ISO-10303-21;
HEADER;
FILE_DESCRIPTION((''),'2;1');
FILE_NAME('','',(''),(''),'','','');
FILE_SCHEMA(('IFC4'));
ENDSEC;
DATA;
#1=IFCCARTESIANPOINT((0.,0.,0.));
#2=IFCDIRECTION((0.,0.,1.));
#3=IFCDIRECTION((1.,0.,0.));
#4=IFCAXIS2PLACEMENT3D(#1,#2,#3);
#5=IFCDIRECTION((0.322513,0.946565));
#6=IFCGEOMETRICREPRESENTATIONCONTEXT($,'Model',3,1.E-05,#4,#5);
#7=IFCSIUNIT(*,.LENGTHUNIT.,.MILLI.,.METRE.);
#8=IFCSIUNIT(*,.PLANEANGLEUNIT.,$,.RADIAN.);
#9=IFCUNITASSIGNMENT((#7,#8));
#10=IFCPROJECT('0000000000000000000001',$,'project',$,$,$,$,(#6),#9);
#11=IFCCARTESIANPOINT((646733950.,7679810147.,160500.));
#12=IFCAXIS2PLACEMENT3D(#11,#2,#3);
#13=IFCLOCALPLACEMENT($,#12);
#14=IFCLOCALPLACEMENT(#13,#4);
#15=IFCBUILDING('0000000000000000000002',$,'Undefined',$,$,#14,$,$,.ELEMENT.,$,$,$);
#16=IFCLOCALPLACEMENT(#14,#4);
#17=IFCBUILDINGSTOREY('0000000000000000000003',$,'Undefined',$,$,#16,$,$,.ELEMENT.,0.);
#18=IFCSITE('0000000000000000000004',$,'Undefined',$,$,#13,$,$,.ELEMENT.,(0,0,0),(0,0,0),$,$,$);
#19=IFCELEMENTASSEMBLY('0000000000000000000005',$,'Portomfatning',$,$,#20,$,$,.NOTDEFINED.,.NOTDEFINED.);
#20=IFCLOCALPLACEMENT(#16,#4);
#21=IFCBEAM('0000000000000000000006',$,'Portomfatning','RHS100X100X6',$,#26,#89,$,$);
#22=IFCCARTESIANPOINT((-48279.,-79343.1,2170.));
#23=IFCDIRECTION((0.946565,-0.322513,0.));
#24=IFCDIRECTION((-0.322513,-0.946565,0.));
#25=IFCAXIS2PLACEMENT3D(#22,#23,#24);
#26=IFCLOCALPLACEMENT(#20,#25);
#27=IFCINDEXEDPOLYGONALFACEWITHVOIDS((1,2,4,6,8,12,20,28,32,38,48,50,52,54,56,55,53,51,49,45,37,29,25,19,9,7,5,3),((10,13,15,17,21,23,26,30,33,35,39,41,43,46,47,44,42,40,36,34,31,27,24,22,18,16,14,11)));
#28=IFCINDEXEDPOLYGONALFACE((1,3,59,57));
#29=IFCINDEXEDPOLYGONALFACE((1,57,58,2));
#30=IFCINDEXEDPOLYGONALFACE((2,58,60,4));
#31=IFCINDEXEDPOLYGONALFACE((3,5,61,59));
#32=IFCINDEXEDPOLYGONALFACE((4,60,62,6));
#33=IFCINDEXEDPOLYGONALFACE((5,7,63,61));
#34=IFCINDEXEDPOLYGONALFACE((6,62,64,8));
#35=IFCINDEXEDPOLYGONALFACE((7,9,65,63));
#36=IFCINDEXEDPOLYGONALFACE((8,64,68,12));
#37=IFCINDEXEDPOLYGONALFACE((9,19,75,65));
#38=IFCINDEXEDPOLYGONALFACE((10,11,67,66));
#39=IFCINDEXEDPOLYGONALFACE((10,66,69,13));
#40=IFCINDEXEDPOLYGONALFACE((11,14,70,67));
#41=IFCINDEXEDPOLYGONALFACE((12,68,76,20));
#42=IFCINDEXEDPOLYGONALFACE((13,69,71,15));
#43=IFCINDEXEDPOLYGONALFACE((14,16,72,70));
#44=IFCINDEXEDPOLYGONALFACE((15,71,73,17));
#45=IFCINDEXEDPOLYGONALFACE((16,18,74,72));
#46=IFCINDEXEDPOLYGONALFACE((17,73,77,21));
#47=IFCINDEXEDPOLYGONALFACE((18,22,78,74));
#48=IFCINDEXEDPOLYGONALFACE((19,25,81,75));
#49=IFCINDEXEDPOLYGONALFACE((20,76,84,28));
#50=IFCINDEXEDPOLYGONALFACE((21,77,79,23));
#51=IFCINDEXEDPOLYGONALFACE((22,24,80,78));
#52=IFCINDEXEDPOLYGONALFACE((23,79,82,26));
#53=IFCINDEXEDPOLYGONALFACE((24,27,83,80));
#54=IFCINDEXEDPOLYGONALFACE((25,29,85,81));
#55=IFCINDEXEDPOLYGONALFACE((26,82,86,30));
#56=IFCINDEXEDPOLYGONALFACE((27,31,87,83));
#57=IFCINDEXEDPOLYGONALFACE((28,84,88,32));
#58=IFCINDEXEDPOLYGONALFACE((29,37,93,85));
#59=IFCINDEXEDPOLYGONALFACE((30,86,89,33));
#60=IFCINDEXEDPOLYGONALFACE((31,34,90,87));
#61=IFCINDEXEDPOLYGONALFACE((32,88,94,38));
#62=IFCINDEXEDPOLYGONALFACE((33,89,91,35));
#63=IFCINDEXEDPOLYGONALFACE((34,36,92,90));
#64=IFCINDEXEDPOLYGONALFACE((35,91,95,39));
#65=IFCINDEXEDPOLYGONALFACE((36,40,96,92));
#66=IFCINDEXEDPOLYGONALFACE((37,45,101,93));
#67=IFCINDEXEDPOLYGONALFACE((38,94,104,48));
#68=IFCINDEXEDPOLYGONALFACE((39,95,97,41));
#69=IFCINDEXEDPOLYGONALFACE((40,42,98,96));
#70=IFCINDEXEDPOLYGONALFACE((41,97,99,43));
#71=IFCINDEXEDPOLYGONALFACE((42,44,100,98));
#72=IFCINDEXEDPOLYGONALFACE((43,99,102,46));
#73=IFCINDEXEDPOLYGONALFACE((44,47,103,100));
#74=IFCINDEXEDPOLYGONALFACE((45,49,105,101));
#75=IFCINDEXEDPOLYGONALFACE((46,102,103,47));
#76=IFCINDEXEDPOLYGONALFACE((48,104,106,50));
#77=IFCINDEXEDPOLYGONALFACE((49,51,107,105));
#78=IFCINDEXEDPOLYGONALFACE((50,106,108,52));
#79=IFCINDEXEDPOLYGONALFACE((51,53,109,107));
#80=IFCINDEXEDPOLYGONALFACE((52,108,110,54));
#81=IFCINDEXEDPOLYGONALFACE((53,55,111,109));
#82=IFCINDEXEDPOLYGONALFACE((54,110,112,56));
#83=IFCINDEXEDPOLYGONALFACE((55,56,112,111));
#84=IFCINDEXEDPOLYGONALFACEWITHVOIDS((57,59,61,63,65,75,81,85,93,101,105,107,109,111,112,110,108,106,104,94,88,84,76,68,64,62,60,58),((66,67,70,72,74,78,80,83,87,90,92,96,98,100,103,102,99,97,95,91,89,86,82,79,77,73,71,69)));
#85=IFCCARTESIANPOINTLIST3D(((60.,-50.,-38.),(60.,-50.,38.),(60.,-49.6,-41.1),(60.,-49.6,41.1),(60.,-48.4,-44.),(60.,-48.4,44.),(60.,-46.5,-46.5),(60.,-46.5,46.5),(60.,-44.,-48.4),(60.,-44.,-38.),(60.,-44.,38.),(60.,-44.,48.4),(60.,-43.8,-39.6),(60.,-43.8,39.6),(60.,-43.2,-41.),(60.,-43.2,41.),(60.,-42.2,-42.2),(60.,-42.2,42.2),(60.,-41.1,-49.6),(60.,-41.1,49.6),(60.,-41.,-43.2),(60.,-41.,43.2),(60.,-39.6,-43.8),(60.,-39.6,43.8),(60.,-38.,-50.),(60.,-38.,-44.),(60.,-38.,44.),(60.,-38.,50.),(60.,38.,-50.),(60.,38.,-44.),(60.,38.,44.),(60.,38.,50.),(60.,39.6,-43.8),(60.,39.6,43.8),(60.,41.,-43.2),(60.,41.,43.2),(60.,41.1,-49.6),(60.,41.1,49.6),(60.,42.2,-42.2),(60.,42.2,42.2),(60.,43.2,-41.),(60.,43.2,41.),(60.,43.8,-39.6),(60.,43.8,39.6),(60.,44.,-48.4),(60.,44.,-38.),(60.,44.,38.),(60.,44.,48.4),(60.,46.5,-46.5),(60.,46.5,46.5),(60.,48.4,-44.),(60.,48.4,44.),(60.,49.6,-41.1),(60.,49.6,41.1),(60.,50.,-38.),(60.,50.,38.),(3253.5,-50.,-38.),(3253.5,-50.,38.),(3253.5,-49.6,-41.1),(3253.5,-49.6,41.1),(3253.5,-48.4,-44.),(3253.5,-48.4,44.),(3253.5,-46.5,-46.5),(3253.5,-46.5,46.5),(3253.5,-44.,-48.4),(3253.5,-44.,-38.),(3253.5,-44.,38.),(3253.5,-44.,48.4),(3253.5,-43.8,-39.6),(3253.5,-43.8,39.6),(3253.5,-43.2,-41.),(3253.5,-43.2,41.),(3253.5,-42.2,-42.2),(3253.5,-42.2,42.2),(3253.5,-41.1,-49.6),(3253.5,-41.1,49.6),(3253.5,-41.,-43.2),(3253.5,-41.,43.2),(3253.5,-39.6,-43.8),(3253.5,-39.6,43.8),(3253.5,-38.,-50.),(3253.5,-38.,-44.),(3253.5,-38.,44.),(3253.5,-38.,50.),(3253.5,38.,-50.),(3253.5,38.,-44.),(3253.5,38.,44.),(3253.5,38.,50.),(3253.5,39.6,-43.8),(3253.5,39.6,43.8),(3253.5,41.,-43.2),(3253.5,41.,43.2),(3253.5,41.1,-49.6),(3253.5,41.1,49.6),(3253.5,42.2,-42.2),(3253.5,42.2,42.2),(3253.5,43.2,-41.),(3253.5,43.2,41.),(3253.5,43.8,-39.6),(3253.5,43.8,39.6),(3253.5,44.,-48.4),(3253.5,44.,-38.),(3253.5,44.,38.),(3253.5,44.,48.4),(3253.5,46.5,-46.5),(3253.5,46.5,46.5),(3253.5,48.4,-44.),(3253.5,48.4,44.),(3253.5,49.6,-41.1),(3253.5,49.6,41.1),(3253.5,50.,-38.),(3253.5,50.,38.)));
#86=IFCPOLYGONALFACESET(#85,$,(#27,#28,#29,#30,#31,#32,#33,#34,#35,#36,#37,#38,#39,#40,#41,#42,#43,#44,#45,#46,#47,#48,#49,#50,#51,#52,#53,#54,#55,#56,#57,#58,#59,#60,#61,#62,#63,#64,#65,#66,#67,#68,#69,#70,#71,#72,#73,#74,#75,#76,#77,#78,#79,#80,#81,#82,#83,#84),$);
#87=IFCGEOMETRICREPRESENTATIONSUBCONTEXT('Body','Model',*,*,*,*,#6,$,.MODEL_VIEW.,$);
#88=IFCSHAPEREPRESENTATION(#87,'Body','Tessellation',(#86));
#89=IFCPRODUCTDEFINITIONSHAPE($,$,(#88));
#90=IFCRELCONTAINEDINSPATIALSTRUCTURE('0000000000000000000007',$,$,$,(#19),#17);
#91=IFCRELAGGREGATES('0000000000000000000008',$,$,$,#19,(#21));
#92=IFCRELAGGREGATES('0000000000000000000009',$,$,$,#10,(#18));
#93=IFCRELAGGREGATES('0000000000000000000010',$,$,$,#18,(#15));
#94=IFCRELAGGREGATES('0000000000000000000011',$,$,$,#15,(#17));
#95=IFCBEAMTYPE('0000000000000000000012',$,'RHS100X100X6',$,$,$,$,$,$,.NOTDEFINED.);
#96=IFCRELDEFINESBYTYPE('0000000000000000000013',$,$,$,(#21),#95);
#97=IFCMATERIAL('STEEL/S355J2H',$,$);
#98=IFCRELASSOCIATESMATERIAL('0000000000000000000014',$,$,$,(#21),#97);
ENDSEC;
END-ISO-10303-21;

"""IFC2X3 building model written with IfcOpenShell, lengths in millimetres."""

from ifc_helpers import new_model, si_unit, direction, frame, origin_with_axes, origin_2d_with_axis, place, context, subcontext, project, spatial, hollow_rectangle, extrude, clip, halfspace, material, type_object, element, aggregate, save


model = new_model("IFC2X3")

# Units and contexts
model_context = context("Model", 3, precision=1e-05, world=origin_with_axes(), true_north=direction((0.322513, 0.946565)))
body_context = subcontext(model_context, "Body", "Model", "MODEL_VIEW")
ifc_project = project(units=[si_unit("LENGTHUNIT", "METRE", prefix="MILLI"), si_unit("PLANEANGLEUNIT", "RADIAN")], contexts=[model_context])

# Site, building, storey
site_placement = place(None, frame((646733950.0, 7679810147.0, 160500.0), z_axis=(0.0, 0.0, 1.0), x_axis=(1.0, 0.0, 0.0)))
site = spatial("IfcSite", under=ifc_project, at=site_placement, Name="Undefined", CompositionType="ELEMENT", RefLatitude=(0, 0, 0), RefLongitude=(0, 0, 0))
building_placement = place(site_placement, origin_with_axes())
building = spatial("IfcBuilding", under=site, at=building_placement, Name="Undefined", CompositionType="ELEMENT")
storey_placement = place(building_placement, origin_with_axes())
storey = spatial("IfcBuildingStorey", under=building, at=storey_placement, Name="Undefined", CompositionType="ELEMENT", Elevation=0.0)

# Shared definitions
ifc_material_1 = material(Name="STEEL/S355J2H")

# Element assembly, beam
assembly_1_placement = place(storey_placement, origin_with_axes())
assembly_1 = element("IfcElementAssembly", 1, at=assembly_1_placement, inside=storey, Name="Portomfatning", AssemblyPlace="NOTDEFINED", PredefinedType="NOTDEFINED")
beam_type_1 = type_object("IfcBeamType", Name="RHS100X100X6", PredefinedType="NOTDEFINED")
beam_1_placement = place(assembly_1_placement, frame((-48279.0, -79343.1, 2170.0), z_axis=(0.946565, -0.322513, 0.0), x_axis=(-0.322513, -0.946565, 0.0)))
beam_1 = element("IfcBeam", 2, at=beam_1_placement, type_object=beam_type_1, material=ifc_material_1, Name="Portomfatning", Description="RHS100X100X6", context=body_context, shape_type="Clipping", body=[
    clip(clip(extrude(hollow_rectangle(XDim=100.0, YDim=100.0, WallThickness=6.0, InnerFilletRadius=6.0, OuterFilletRadius=12.0, at=origin_2d_with_axis()), frame((3315.1, 0.0, 0.0), z_axis=(-1.0, 0.0, 0.0), x_axis=(0.0, -1.0, 0.0)), (0.0, 0.0, 1.0), 3316.8), halfspace(frame((3253.5, 0.0, -50.0), z_axis=(-1.0, 0.0, 0.0), x_axis=(0.0, 1.0, 0.0)), True)), halfspace(frame((60.0, 50.0, 0.0), z_axis=(1.0, 0.0, 0.0), x_axis=(0.0, 0.0, -1.0)), True)),
])

aggregate(assembly_1, [beam_1])

save(model, "model.ifc")
